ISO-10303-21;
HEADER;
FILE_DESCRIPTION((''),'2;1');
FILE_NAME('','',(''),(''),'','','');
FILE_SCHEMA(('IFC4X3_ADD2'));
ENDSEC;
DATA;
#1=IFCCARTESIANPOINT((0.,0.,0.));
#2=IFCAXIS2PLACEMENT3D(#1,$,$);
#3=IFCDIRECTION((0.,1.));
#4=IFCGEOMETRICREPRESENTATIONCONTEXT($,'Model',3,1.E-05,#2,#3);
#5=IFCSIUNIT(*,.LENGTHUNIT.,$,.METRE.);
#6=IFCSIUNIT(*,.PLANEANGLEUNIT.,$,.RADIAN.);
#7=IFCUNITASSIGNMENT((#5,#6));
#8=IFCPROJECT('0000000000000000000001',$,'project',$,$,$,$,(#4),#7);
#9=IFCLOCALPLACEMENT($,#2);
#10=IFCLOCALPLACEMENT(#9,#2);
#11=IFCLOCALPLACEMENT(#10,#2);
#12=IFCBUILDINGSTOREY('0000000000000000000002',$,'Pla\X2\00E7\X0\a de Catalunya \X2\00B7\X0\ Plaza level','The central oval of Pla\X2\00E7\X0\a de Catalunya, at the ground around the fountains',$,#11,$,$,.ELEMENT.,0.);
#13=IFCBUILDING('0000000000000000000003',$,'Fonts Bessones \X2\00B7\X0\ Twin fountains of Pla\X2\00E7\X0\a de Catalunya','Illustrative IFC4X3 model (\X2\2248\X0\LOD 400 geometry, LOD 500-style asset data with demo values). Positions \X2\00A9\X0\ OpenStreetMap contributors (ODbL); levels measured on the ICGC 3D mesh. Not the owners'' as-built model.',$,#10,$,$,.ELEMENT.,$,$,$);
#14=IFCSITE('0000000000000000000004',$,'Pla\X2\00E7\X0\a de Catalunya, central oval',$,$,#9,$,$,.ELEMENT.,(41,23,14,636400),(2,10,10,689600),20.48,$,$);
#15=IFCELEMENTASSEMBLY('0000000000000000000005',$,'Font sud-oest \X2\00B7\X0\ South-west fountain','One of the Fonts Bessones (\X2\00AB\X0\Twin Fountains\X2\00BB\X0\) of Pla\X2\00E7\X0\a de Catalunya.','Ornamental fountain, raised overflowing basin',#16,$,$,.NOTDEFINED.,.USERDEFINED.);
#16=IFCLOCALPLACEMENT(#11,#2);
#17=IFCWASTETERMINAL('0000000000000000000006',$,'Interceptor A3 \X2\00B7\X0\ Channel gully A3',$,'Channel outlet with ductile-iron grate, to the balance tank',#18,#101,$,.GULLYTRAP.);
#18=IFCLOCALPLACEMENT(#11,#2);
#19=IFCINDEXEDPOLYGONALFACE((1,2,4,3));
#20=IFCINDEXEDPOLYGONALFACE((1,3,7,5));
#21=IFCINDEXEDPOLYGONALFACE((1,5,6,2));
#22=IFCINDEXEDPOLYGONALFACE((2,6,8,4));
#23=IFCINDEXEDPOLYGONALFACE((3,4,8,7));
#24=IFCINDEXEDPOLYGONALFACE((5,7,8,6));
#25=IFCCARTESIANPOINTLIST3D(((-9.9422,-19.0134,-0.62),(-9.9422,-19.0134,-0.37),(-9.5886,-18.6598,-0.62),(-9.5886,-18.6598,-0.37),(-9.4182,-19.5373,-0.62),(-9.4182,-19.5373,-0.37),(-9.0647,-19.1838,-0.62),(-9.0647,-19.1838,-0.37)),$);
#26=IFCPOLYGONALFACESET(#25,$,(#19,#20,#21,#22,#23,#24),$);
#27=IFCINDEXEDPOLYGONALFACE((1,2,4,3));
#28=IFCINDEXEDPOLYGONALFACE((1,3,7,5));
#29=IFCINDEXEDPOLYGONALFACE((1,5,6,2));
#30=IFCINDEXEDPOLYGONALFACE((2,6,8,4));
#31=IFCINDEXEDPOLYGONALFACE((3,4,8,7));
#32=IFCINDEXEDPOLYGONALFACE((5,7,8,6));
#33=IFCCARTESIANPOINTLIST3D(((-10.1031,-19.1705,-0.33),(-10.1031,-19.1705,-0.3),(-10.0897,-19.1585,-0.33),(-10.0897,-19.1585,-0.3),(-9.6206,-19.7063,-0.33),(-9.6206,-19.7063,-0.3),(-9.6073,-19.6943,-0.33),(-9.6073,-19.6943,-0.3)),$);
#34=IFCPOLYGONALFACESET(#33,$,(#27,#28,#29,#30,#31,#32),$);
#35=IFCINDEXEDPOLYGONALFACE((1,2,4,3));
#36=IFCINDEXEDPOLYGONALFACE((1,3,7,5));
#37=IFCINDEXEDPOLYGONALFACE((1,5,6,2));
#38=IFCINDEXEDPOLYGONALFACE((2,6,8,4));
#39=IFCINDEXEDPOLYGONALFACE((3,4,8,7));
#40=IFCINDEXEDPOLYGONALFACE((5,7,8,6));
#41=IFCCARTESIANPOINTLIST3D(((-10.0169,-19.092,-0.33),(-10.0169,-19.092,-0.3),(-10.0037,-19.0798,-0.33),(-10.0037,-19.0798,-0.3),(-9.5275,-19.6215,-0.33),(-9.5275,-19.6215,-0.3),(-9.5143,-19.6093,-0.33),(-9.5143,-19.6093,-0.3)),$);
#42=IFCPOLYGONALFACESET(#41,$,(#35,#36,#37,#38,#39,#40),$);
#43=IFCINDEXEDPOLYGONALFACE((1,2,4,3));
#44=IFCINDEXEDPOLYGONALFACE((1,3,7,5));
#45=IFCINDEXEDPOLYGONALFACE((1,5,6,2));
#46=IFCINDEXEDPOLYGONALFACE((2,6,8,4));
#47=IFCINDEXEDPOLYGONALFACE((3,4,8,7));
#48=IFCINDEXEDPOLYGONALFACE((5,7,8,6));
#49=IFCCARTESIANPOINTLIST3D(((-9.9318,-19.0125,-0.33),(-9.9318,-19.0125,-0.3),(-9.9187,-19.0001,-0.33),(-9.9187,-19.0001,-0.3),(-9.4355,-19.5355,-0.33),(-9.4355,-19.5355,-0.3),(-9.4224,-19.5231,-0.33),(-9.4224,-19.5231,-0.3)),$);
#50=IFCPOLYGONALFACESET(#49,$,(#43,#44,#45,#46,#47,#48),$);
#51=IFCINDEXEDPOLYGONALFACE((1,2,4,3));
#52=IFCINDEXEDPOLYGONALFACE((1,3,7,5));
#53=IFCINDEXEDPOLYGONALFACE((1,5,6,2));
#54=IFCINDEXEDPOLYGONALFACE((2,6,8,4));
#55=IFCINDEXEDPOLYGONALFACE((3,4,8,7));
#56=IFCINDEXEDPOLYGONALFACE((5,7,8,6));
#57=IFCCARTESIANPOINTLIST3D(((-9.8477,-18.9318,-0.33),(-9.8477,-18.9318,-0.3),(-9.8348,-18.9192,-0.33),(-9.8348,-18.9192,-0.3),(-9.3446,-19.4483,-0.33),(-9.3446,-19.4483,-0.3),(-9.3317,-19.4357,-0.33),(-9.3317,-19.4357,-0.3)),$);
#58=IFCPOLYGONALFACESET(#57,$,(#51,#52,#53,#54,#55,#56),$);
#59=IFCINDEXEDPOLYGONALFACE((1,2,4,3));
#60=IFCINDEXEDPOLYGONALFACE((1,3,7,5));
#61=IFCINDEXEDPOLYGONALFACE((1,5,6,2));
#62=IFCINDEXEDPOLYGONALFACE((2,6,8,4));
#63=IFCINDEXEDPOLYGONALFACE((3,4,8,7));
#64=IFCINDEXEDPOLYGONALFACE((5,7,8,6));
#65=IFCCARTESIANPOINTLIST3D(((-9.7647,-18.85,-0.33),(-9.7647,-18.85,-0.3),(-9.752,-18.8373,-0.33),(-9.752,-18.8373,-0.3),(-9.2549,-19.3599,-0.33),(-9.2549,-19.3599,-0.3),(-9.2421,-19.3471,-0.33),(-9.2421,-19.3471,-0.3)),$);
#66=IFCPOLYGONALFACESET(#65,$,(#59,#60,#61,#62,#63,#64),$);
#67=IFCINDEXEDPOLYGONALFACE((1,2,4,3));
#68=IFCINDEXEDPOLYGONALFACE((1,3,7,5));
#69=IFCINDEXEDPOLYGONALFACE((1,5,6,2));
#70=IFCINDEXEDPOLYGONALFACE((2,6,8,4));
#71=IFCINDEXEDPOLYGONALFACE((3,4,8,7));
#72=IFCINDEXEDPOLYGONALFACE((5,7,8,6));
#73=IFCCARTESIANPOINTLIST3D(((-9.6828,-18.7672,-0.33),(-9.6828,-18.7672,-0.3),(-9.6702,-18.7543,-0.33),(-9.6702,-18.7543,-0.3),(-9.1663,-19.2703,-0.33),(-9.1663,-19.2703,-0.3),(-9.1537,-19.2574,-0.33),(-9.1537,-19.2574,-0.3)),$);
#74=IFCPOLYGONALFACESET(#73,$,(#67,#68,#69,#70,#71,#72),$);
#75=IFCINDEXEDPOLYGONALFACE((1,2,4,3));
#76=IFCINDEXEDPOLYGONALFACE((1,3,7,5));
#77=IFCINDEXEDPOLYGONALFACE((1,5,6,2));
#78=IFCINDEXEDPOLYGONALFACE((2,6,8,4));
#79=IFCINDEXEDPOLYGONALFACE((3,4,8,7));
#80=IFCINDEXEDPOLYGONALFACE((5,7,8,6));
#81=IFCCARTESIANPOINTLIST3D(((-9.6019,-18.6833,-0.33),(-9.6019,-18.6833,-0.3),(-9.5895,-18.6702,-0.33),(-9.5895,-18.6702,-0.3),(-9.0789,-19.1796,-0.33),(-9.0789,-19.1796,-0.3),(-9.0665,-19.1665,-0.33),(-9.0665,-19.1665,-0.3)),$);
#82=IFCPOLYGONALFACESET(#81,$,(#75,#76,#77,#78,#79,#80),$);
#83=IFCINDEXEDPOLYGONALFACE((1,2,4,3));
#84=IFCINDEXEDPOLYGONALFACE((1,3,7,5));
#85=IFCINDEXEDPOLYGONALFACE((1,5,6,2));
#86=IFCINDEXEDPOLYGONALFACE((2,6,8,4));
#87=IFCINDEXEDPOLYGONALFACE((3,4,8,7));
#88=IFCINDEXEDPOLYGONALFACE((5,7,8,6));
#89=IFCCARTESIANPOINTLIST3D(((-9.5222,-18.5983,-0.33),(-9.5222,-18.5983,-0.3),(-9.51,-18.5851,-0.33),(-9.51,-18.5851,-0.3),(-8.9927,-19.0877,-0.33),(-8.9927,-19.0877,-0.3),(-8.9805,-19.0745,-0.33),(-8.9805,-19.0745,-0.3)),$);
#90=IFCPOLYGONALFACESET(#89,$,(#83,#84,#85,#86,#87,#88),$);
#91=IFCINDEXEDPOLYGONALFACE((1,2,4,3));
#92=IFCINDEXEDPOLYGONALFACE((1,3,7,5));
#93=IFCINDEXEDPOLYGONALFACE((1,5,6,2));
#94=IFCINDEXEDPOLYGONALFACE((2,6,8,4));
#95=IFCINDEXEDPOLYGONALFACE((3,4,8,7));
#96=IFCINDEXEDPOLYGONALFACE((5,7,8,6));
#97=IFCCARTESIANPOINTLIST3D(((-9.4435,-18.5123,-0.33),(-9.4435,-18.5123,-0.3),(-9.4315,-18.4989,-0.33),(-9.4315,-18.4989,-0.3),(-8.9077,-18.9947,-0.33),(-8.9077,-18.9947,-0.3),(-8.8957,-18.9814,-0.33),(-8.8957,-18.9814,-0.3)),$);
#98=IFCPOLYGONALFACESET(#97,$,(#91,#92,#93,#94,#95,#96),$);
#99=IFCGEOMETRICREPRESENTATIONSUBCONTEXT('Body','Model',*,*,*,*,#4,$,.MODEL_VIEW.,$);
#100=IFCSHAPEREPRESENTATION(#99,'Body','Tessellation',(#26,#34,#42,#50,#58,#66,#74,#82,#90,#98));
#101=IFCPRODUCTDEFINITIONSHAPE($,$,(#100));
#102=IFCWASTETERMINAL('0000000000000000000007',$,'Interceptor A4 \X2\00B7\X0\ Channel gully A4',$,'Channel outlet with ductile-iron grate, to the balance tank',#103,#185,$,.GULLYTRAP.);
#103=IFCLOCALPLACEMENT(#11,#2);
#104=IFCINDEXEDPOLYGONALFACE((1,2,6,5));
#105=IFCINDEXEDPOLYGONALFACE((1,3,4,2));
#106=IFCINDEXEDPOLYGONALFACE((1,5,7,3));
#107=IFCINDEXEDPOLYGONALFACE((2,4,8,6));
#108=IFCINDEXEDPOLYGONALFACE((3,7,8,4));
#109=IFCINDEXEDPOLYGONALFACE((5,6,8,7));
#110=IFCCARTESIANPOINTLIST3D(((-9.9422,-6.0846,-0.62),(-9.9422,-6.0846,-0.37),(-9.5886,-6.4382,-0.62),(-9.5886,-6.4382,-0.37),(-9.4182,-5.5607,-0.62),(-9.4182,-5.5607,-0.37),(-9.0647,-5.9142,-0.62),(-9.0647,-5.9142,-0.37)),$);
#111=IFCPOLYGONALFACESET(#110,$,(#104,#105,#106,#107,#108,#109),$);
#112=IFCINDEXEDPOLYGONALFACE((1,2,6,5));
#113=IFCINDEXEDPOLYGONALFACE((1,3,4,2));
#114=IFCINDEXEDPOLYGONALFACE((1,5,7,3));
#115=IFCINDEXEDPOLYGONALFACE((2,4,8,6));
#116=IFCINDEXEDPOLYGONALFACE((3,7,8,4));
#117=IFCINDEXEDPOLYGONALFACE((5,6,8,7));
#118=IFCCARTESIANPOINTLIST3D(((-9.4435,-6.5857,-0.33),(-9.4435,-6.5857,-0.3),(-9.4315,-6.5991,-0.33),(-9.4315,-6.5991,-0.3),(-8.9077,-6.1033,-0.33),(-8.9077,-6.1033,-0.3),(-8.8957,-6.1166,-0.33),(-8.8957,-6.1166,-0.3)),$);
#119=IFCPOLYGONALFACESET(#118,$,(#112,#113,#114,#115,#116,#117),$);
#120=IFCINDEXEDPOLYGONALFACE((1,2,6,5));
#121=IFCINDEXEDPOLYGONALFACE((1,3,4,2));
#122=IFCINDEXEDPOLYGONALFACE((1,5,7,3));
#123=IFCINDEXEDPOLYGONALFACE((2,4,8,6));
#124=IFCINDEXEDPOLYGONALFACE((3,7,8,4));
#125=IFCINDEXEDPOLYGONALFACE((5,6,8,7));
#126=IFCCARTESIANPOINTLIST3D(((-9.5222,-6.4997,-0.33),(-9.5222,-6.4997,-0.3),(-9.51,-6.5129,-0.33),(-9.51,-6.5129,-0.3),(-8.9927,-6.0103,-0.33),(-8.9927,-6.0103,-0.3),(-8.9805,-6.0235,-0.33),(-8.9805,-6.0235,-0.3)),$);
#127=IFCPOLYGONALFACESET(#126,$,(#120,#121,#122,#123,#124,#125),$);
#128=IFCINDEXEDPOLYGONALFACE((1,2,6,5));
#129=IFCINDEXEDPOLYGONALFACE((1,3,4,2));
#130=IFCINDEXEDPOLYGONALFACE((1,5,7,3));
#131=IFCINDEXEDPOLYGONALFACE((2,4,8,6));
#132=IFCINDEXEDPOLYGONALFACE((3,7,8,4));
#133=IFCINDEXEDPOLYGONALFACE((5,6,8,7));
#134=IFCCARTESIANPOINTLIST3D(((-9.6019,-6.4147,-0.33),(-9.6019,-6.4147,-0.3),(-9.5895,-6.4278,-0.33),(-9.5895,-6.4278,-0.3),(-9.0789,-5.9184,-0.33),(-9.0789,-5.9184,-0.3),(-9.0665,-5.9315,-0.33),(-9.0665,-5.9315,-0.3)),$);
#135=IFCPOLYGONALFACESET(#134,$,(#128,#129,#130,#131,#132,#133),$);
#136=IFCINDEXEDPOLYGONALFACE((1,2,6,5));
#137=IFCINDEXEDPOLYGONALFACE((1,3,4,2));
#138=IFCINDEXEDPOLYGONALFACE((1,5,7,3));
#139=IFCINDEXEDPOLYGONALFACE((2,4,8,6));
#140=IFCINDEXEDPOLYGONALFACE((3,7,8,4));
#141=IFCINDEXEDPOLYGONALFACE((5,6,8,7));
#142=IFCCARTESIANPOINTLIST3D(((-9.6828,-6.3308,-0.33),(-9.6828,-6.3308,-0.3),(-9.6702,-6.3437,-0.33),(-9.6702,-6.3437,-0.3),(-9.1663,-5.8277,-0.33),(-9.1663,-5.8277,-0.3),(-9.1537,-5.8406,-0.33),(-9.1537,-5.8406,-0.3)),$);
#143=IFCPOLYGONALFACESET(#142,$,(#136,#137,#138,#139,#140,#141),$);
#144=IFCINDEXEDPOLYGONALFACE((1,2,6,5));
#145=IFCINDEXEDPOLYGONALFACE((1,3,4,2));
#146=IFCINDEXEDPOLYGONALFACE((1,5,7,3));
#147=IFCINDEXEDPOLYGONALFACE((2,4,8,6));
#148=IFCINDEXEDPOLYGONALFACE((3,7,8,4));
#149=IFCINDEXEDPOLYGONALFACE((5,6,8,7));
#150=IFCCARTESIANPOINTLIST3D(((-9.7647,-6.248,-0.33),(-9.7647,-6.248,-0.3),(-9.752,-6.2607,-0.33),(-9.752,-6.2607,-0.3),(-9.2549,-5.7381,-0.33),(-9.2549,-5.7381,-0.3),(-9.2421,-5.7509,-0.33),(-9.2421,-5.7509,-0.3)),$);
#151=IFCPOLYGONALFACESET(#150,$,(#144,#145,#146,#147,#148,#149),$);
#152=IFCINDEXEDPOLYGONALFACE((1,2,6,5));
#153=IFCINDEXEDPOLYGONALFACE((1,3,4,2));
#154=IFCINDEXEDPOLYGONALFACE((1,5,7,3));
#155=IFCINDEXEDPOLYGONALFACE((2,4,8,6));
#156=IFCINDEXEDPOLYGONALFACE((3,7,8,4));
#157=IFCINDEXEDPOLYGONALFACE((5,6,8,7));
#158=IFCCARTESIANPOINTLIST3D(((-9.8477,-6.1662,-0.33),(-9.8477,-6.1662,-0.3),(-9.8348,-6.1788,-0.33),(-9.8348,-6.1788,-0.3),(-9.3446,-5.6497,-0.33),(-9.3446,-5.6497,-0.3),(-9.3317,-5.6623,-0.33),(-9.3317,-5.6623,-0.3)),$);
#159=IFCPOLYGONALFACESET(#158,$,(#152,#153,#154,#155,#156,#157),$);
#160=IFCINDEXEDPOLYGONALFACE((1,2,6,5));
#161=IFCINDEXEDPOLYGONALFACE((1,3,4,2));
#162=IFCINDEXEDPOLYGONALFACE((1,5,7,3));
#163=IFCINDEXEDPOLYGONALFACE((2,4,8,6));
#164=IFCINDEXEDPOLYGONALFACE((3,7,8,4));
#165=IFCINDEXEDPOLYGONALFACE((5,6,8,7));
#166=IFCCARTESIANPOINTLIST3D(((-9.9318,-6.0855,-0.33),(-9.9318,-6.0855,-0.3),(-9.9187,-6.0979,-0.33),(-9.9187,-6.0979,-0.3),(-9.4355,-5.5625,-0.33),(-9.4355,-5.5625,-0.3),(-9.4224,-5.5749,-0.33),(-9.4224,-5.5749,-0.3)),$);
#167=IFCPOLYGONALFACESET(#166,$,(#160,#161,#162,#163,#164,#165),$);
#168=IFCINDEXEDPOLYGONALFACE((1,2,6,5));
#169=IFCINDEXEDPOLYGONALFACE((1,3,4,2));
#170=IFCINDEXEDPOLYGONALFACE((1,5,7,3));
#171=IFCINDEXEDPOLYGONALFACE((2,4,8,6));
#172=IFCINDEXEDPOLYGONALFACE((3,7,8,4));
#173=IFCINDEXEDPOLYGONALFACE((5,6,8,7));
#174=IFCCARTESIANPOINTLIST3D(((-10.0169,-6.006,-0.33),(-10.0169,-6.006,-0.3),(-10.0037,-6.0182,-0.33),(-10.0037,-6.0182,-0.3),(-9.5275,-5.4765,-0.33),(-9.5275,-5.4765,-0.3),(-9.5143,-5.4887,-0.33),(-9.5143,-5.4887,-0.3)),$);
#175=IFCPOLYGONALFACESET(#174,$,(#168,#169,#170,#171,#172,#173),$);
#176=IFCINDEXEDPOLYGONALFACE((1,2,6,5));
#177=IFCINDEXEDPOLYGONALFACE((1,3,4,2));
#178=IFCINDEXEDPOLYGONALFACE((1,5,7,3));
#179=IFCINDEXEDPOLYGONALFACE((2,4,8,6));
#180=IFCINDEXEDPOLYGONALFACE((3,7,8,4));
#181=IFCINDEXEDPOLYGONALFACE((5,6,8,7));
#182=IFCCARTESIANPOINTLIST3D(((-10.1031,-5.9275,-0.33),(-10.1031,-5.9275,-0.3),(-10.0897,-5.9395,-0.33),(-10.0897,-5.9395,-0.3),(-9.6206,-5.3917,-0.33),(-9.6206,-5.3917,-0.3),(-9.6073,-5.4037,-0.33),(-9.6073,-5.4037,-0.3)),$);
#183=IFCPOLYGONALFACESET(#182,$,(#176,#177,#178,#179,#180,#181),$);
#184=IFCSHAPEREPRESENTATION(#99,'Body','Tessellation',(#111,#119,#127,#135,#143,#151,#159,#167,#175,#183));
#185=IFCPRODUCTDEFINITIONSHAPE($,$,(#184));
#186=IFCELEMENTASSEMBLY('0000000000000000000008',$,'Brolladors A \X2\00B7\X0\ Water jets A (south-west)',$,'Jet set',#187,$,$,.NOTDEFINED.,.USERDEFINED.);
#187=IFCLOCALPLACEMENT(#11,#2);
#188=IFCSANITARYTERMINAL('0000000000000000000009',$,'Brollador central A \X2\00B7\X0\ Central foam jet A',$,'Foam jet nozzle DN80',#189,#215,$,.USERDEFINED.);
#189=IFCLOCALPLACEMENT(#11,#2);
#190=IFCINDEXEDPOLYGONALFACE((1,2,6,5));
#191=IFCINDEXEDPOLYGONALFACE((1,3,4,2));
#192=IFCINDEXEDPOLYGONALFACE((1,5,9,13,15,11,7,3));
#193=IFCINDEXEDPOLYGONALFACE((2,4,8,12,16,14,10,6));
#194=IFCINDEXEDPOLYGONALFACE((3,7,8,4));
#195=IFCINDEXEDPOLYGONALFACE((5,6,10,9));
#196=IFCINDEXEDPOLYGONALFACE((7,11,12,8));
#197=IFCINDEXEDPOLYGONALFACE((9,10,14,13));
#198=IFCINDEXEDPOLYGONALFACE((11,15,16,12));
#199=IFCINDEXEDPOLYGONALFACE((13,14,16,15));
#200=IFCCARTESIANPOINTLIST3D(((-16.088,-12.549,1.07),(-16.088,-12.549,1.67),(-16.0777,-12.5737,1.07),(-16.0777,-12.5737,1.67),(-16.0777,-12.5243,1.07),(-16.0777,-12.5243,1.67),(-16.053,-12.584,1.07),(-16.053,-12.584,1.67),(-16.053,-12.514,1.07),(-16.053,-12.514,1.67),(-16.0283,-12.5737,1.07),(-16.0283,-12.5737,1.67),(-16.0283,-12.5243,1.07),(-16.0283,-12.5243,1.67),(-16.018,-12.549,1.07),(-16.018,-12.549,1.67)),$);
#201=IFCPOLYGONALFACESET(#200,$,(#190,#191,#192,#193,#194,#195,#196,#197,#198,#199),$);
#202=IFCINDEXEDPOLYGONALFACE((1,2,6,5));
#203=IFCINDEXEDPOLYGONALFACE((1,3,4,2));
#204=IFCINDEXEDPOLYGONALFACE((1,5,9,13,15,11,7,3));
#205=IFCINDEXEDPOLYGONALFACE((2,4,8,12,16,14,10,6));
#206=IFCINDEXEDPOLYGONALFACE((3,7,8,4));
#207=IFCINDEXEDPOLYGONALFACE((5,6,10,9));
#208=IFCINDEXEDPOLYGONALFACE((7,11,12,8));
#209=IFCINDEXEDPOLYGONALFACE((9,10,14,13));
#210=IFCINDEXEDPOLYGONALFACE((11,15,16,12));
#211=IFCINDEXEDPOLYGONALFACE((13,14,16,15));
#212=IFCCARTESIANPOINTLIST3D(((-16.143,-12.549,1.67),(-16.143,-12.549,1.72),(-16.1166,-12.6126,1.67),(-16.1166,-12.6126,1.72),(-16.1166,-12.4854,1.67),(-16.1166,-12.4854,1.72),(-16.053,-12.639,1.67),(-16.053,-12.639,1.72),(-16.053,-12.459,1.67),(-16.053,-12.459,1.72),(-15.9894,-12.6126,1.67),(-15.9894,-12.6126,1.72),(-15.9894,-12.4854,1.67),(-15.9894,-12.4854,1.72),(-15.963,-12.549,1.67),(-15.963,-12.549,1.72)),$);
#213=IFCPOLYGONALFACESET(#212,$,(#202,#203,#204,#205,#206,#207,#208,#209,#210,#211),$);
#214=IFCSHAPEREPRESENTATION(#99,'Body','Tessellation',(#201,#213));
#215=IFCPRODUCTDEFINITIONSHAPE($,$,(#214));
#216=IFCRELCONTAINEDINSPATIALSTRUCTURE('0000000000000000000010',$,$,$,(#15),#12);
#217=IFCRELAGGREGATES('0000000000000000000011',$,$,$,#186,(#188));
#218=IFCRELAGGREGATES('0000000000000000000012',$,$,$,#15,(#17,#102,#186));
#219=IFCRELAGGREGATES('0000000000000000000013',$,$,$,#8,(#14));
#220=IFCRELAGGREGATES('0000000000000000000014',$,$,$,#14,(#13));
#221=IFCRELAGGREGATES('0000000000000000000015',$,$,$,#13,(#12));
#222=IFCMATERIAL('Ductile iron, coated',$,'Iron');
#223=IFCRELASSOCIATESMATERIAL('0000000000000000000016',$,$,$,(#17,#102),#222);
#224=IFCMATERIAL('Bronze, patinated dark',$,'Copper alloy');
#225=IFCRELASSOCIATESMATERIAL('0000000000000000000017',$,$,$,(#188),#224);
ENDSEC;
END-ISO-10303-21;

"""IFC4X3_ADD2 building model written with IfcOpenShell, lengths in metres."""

from ifc_helpers import new_model, si_unit, direction, frame, frame_2d, origin, place, context, subcontext, project, spatial, polyline, rectangle, outline, extrude, material, element, aggregate, save


model = new_model("IFC4X3_ADD2")

# Units and contexts
model_context = context("Model", 3, precision=1e-05, world=origin(), true_north=direction((0.0, 1.0)))
body_context = subcontext(model_context, "Body", "Model", "MODEL_VIEW")
ifc_project = project(units=[si_unit("LENGTHUNIT", "METRE"), si_unit("PLANEANGLEUNIT", "RADIAN")], contexts=[model_context])

# Site, building, storey
site_placement = place(None, origin())
site = spatial("IfcSite", under=ifc_project, at=site_placement, Name="Plaça de Catalunya, central oval", CompositionType="ELEMENT", RefLatitude=(41, 23, 14, 636400), RefLongitude=(2, 10, 10, 689600), RefElevation=20.48)
building_placement = place(site_placement, origin())
building = spatial("IfcBuilding", under=site, at=building_placement, Name="Fonts Bessones · Twin fountains of Plaça de Catalunya", Description="Illustrative IFC4X3 model (≈LOD 400 geometry, LOD 500-style asset data with demo values). Positions © OpenStreetMap contributors (ODbL); levels measured on the ICGC 3D mesh. Not the owners' as-built model.", CompositionType="ELEMENT")
storey_placement = place(building_placement, origin())
storey = spatial("IfcBuildingStorey", under=building, at=storey_placement, Name="Plaça de Catalunya · Plaza level", Description="The central oval of Plaça de Catalunya, at the ground around the fountains", CompositionType="ELEMENT", Elevation=0.0)

# Element assemblies, waste terminals, sanitary terminal
assembly_1_placement = place(building_placement, origin())
assembly_1 = element("IfcElementAssembly", 1, at=assembly_1_placement, inside=storey, Name="Font sud-oest · South-west fountain", Description="One of the Fonts Bessones («Twin Fountains») of Plaça de Catalunya.", ObjectType="Ornamental fountain, raised overflowing basin", AssemblyPlace="NOTDEFINED", PredefinedType="USERDEFINED")
ifc_material_1 = material(Name="Ductile iron, coated", Category="Iron")
waste_terminal_1_placement = place(building_placement, origin())
waste_terminal_1 = element("IfcWasteTerminal", 2, at=waste_terminal_1_placement, material=ifc_material_1, Name="Interceptor A3 · Channel gully A3", ObjectType="Channel outlet with ductile-iron grate, to the balance tank", PredefinedType="GULLYTRAP", context=body_context, shape_type="SweptSolid", body=[
    extrude(rectangle(XDim=0.741, YDim=0.5, at=frame_2d((0.0, 0.0), x_axis=(0.707107, -0.707107))), frame((-9.5034, -19.0986, -0.62)), (0.0, 0.0, 1.0), 0.25),
    extrude(rectangle(XDim=0.721, YDim=0.018, at=frame_2d((0.0, 0.0), x_axis=(0.669131, -0.743145))), frame((-9.8552, -19.4324, -0.33)), (0.0, 0.0, 1.0), 0.03),
    extrude(rectangle(XDim=0.721, YDim=0.018, at=frame_2d((0.0, 0.0), x_axis=(0.678801, -0.734323))), frame((-9.7656, -19.3507, -0.33)), (0.0, 0.0, 1.0), 0.03),
    extrude(rectangle(XDim=0.721, YDim=0.018, at=frame_2d((0.0, 0.0), x_axis=(0.688355, -0.725374))), frame((-9.6771, -19.2678, -0.33)), (0.0, 0.0, 1.0), 0.03),
    extrude(rectangle(XDim=0.721, YDim=0.018, at=frame_2d((0.0, 0.0), x_axis=(0.69779, -0.716302))), frame((-9.5897, -19.1837, -0.33)), (0.0, 0.0, 1.0), 0.03),
    extrude(rectangle(XDim=0.721, YDim=0.018, at=frame_2d((0.0, 0.0), x_axis=(0.707107, -0.707107))), frame((-9.5034, -19.0986, -0.33)), (0.0, 0.0, 1.0), 0.03),
    extrude(rectangle(XDim=0.721, YDim=0.018, at=frame_2d((0.0, 0.0), x_axis=(0.716302, -0.69779))), frame((-9.4183, -19.0123, -0.33)), (0.0, 0.0, 1.0), 0.03),
    extrude(rectangle(XDim=0.721, YDim=0.018, at=frame_2d((0.0, 0.0), x_axis=(0.725374, -0.688355))), frame((-9.3342, -18.9249, -0.33)), (0.0, 0.0, 1.0), 0.03),
    extrude(rectangle(XDim=0.721, YDim=0.018, at=frame_2d((0.0, 0.0), x_axis=(0.734323, -0.678801))), frame((-9.2513, -18.8364, -0.33)), (0.0, 0.0, 1.0), 0.03),
    extrude(rectangle(XDim=0.721, YDim=0.018, at=frame_2d((0.0, 0.0), x_axis=(0.743145, -0.669131))), frame((-9.1696, -18.7468, -0.33)), (0.0, 0.0, 1.0), 0.03),
])
waste_terminal_2_placement = place(building_placement, origin())
waste_terminal_2 = element("IfcWasteTerminal", 3, at=waste_terminal_2_placement, material=ifc_material_1, Name="Interceptor A4 · Channel gully A4", ObjectType="Channel outlet with ductile-iron grate, to the balance tank", PredefinedType="GULLYTRAP", context=body_context, shape_type="SweptSolid", body=[
    extrude(rectangle(XDim=0.741, YDim=0.5, at=frame_2d((0.0, 0.0), x_axis=(0.707107, 0.707107))), frame((-9.5034, -5.9994, -0.62)), (0.0, 0.0, 1.0), 0.25),
    extrude(rectangle(XDim=0.721, YDim=0.018, at=frame_2d((0.0, 0.0), x_axis=(0.743145, 0.669131))), frame((-9.1696, -6.3512, -0.33)), (0.0, 0.0, 1.0), 0.03),
    extrude(rectangle(XDim=0.721, YDim=0.018, at=frame_2d((0.0, 0.0), x_axis=(0.734323, 0.678801))), frame((-9.2513, -6.2616, -0.33)), (0.0, 0.0, 1.0), 0.03),
    extrude(rectangle(XDim=0.721, YDim=0.018, at=frame_2d((0.0, 0.0), x_axis=(0.725374, 0.688355))), frame((-9.3342, -6.1731, -0.33)), (0.0, 0.0, 1.0), 0.03),
    extrude(rectangle(XDim=0.721, YDim=0.018, at=frame_2d((0.0, 0.0), x_axis=(0.716302, 0.69779))), frame((-9.4183, -6.0857, -0.33)), (0.0, 0.0, 1.0), 0.03),
    extrude(rectangle(XDim=0.721, YDim=0.018, at=frame_2d((0.0, 0.0), x_axis=(0.707107, 0.707107))), frame((-9.5034, -5.9994, -0.33)), (0.0, 0.0, 1.0), 0.03),
    extrude(rectangle(XDim=0.721, YDim=0.018, at=frame_2d((0.0, 0.0), x_axis=(0.69779, 0.716302))), frame((-9.5897, -5.9143, -0.33)), (0.0, 0.0, 1.0), 0.03),
    extrude(rectangle(XDim=0.721, YDim=0.018, at=frame_2d((0.0, 0.0), x_axis=(0.688355, 0.725374))), frame((-9.6771, -5.8302, -0.33)), (0.0, 0.0, 1.0), 0.03),
    extrude(rectangle(XDim=0.721, YDim=0.018, at=frame_2d((0.0, 0.0), x_axis=(0.678801, 0.734323))), frame((-9.7656, -5.7473, -0.33)), (0.0, 0.0, 1.0), 0.03),
    extrude(rectangle(XDim=0.721, YDim=0.018, at=frame_2d((0.0, 0.0), x_axis=(0.669131, 0.743145))), frame((-9.8552, -5.6656, -0.33)), (0.0, 0.0, 1.0), 0.03),
])
assembly_2_placement = place(building_placement, origin())
assembly_2 = element("IfcElementAssembly", 4, at=assembly_2_placement, Name="Brolladors A · Water jets A (south-west)", ObjectType="Jet set", AssemblyPlace="NOTDEFINED", PredefinedType="USERDEFINED")
ifc_material_2 = material(Name="Bronze, patinated dark", Category="Copper alloy")
sanitary_terminal_1_placement = place(building_placement, origin())
sanitary_terminal_1 = element("IfcSanitaryTerminal", 5, at=sanitary_terminal_1_placement, material=ifc_material_2, Name="Brollador central A · Central foam jet A", ObjectType="Foam jet nozzle DN80", PredefinedType="USERDEFINED", context=body_context, shape_type="SweptSolid", body=[
    extrude(outline(polyline([(-16.018, -12.549), (-16.0283, -12.5243), (-16.053, -12.514), (-16.0777, -12.5243), (-16.088, -12.549), (-16.0777, -12.5737), (-16.053, -12.584), (-16.0283, -12.5737), (-16.018, -12.549)])), frame((0.0, 0.0, 1.07)), (0.0, 0.0, 1.0), 0.6),
    extrude(outline(polyline([(-15.963, -12.549), (-15.9894, -12.4854), (-16.053, -12.459), (-16.1166, -12.4854), (-16.143, -12.549), (-16.1166, -12.6126), (-16.053, -12.639), (-15.9894, -12.6126), (-15.963, -12.549)])), frame((0.0, 0.0, 1.67)), (0.0, 0.0, 1.0), 0.05),
])
aggregate(assembly_2, [sanitary_terminal_1])
aggregate(assembly_1, [waste_terminal_1, waste_terminal_2, assembly_2])

save(model, "model.ifc")
